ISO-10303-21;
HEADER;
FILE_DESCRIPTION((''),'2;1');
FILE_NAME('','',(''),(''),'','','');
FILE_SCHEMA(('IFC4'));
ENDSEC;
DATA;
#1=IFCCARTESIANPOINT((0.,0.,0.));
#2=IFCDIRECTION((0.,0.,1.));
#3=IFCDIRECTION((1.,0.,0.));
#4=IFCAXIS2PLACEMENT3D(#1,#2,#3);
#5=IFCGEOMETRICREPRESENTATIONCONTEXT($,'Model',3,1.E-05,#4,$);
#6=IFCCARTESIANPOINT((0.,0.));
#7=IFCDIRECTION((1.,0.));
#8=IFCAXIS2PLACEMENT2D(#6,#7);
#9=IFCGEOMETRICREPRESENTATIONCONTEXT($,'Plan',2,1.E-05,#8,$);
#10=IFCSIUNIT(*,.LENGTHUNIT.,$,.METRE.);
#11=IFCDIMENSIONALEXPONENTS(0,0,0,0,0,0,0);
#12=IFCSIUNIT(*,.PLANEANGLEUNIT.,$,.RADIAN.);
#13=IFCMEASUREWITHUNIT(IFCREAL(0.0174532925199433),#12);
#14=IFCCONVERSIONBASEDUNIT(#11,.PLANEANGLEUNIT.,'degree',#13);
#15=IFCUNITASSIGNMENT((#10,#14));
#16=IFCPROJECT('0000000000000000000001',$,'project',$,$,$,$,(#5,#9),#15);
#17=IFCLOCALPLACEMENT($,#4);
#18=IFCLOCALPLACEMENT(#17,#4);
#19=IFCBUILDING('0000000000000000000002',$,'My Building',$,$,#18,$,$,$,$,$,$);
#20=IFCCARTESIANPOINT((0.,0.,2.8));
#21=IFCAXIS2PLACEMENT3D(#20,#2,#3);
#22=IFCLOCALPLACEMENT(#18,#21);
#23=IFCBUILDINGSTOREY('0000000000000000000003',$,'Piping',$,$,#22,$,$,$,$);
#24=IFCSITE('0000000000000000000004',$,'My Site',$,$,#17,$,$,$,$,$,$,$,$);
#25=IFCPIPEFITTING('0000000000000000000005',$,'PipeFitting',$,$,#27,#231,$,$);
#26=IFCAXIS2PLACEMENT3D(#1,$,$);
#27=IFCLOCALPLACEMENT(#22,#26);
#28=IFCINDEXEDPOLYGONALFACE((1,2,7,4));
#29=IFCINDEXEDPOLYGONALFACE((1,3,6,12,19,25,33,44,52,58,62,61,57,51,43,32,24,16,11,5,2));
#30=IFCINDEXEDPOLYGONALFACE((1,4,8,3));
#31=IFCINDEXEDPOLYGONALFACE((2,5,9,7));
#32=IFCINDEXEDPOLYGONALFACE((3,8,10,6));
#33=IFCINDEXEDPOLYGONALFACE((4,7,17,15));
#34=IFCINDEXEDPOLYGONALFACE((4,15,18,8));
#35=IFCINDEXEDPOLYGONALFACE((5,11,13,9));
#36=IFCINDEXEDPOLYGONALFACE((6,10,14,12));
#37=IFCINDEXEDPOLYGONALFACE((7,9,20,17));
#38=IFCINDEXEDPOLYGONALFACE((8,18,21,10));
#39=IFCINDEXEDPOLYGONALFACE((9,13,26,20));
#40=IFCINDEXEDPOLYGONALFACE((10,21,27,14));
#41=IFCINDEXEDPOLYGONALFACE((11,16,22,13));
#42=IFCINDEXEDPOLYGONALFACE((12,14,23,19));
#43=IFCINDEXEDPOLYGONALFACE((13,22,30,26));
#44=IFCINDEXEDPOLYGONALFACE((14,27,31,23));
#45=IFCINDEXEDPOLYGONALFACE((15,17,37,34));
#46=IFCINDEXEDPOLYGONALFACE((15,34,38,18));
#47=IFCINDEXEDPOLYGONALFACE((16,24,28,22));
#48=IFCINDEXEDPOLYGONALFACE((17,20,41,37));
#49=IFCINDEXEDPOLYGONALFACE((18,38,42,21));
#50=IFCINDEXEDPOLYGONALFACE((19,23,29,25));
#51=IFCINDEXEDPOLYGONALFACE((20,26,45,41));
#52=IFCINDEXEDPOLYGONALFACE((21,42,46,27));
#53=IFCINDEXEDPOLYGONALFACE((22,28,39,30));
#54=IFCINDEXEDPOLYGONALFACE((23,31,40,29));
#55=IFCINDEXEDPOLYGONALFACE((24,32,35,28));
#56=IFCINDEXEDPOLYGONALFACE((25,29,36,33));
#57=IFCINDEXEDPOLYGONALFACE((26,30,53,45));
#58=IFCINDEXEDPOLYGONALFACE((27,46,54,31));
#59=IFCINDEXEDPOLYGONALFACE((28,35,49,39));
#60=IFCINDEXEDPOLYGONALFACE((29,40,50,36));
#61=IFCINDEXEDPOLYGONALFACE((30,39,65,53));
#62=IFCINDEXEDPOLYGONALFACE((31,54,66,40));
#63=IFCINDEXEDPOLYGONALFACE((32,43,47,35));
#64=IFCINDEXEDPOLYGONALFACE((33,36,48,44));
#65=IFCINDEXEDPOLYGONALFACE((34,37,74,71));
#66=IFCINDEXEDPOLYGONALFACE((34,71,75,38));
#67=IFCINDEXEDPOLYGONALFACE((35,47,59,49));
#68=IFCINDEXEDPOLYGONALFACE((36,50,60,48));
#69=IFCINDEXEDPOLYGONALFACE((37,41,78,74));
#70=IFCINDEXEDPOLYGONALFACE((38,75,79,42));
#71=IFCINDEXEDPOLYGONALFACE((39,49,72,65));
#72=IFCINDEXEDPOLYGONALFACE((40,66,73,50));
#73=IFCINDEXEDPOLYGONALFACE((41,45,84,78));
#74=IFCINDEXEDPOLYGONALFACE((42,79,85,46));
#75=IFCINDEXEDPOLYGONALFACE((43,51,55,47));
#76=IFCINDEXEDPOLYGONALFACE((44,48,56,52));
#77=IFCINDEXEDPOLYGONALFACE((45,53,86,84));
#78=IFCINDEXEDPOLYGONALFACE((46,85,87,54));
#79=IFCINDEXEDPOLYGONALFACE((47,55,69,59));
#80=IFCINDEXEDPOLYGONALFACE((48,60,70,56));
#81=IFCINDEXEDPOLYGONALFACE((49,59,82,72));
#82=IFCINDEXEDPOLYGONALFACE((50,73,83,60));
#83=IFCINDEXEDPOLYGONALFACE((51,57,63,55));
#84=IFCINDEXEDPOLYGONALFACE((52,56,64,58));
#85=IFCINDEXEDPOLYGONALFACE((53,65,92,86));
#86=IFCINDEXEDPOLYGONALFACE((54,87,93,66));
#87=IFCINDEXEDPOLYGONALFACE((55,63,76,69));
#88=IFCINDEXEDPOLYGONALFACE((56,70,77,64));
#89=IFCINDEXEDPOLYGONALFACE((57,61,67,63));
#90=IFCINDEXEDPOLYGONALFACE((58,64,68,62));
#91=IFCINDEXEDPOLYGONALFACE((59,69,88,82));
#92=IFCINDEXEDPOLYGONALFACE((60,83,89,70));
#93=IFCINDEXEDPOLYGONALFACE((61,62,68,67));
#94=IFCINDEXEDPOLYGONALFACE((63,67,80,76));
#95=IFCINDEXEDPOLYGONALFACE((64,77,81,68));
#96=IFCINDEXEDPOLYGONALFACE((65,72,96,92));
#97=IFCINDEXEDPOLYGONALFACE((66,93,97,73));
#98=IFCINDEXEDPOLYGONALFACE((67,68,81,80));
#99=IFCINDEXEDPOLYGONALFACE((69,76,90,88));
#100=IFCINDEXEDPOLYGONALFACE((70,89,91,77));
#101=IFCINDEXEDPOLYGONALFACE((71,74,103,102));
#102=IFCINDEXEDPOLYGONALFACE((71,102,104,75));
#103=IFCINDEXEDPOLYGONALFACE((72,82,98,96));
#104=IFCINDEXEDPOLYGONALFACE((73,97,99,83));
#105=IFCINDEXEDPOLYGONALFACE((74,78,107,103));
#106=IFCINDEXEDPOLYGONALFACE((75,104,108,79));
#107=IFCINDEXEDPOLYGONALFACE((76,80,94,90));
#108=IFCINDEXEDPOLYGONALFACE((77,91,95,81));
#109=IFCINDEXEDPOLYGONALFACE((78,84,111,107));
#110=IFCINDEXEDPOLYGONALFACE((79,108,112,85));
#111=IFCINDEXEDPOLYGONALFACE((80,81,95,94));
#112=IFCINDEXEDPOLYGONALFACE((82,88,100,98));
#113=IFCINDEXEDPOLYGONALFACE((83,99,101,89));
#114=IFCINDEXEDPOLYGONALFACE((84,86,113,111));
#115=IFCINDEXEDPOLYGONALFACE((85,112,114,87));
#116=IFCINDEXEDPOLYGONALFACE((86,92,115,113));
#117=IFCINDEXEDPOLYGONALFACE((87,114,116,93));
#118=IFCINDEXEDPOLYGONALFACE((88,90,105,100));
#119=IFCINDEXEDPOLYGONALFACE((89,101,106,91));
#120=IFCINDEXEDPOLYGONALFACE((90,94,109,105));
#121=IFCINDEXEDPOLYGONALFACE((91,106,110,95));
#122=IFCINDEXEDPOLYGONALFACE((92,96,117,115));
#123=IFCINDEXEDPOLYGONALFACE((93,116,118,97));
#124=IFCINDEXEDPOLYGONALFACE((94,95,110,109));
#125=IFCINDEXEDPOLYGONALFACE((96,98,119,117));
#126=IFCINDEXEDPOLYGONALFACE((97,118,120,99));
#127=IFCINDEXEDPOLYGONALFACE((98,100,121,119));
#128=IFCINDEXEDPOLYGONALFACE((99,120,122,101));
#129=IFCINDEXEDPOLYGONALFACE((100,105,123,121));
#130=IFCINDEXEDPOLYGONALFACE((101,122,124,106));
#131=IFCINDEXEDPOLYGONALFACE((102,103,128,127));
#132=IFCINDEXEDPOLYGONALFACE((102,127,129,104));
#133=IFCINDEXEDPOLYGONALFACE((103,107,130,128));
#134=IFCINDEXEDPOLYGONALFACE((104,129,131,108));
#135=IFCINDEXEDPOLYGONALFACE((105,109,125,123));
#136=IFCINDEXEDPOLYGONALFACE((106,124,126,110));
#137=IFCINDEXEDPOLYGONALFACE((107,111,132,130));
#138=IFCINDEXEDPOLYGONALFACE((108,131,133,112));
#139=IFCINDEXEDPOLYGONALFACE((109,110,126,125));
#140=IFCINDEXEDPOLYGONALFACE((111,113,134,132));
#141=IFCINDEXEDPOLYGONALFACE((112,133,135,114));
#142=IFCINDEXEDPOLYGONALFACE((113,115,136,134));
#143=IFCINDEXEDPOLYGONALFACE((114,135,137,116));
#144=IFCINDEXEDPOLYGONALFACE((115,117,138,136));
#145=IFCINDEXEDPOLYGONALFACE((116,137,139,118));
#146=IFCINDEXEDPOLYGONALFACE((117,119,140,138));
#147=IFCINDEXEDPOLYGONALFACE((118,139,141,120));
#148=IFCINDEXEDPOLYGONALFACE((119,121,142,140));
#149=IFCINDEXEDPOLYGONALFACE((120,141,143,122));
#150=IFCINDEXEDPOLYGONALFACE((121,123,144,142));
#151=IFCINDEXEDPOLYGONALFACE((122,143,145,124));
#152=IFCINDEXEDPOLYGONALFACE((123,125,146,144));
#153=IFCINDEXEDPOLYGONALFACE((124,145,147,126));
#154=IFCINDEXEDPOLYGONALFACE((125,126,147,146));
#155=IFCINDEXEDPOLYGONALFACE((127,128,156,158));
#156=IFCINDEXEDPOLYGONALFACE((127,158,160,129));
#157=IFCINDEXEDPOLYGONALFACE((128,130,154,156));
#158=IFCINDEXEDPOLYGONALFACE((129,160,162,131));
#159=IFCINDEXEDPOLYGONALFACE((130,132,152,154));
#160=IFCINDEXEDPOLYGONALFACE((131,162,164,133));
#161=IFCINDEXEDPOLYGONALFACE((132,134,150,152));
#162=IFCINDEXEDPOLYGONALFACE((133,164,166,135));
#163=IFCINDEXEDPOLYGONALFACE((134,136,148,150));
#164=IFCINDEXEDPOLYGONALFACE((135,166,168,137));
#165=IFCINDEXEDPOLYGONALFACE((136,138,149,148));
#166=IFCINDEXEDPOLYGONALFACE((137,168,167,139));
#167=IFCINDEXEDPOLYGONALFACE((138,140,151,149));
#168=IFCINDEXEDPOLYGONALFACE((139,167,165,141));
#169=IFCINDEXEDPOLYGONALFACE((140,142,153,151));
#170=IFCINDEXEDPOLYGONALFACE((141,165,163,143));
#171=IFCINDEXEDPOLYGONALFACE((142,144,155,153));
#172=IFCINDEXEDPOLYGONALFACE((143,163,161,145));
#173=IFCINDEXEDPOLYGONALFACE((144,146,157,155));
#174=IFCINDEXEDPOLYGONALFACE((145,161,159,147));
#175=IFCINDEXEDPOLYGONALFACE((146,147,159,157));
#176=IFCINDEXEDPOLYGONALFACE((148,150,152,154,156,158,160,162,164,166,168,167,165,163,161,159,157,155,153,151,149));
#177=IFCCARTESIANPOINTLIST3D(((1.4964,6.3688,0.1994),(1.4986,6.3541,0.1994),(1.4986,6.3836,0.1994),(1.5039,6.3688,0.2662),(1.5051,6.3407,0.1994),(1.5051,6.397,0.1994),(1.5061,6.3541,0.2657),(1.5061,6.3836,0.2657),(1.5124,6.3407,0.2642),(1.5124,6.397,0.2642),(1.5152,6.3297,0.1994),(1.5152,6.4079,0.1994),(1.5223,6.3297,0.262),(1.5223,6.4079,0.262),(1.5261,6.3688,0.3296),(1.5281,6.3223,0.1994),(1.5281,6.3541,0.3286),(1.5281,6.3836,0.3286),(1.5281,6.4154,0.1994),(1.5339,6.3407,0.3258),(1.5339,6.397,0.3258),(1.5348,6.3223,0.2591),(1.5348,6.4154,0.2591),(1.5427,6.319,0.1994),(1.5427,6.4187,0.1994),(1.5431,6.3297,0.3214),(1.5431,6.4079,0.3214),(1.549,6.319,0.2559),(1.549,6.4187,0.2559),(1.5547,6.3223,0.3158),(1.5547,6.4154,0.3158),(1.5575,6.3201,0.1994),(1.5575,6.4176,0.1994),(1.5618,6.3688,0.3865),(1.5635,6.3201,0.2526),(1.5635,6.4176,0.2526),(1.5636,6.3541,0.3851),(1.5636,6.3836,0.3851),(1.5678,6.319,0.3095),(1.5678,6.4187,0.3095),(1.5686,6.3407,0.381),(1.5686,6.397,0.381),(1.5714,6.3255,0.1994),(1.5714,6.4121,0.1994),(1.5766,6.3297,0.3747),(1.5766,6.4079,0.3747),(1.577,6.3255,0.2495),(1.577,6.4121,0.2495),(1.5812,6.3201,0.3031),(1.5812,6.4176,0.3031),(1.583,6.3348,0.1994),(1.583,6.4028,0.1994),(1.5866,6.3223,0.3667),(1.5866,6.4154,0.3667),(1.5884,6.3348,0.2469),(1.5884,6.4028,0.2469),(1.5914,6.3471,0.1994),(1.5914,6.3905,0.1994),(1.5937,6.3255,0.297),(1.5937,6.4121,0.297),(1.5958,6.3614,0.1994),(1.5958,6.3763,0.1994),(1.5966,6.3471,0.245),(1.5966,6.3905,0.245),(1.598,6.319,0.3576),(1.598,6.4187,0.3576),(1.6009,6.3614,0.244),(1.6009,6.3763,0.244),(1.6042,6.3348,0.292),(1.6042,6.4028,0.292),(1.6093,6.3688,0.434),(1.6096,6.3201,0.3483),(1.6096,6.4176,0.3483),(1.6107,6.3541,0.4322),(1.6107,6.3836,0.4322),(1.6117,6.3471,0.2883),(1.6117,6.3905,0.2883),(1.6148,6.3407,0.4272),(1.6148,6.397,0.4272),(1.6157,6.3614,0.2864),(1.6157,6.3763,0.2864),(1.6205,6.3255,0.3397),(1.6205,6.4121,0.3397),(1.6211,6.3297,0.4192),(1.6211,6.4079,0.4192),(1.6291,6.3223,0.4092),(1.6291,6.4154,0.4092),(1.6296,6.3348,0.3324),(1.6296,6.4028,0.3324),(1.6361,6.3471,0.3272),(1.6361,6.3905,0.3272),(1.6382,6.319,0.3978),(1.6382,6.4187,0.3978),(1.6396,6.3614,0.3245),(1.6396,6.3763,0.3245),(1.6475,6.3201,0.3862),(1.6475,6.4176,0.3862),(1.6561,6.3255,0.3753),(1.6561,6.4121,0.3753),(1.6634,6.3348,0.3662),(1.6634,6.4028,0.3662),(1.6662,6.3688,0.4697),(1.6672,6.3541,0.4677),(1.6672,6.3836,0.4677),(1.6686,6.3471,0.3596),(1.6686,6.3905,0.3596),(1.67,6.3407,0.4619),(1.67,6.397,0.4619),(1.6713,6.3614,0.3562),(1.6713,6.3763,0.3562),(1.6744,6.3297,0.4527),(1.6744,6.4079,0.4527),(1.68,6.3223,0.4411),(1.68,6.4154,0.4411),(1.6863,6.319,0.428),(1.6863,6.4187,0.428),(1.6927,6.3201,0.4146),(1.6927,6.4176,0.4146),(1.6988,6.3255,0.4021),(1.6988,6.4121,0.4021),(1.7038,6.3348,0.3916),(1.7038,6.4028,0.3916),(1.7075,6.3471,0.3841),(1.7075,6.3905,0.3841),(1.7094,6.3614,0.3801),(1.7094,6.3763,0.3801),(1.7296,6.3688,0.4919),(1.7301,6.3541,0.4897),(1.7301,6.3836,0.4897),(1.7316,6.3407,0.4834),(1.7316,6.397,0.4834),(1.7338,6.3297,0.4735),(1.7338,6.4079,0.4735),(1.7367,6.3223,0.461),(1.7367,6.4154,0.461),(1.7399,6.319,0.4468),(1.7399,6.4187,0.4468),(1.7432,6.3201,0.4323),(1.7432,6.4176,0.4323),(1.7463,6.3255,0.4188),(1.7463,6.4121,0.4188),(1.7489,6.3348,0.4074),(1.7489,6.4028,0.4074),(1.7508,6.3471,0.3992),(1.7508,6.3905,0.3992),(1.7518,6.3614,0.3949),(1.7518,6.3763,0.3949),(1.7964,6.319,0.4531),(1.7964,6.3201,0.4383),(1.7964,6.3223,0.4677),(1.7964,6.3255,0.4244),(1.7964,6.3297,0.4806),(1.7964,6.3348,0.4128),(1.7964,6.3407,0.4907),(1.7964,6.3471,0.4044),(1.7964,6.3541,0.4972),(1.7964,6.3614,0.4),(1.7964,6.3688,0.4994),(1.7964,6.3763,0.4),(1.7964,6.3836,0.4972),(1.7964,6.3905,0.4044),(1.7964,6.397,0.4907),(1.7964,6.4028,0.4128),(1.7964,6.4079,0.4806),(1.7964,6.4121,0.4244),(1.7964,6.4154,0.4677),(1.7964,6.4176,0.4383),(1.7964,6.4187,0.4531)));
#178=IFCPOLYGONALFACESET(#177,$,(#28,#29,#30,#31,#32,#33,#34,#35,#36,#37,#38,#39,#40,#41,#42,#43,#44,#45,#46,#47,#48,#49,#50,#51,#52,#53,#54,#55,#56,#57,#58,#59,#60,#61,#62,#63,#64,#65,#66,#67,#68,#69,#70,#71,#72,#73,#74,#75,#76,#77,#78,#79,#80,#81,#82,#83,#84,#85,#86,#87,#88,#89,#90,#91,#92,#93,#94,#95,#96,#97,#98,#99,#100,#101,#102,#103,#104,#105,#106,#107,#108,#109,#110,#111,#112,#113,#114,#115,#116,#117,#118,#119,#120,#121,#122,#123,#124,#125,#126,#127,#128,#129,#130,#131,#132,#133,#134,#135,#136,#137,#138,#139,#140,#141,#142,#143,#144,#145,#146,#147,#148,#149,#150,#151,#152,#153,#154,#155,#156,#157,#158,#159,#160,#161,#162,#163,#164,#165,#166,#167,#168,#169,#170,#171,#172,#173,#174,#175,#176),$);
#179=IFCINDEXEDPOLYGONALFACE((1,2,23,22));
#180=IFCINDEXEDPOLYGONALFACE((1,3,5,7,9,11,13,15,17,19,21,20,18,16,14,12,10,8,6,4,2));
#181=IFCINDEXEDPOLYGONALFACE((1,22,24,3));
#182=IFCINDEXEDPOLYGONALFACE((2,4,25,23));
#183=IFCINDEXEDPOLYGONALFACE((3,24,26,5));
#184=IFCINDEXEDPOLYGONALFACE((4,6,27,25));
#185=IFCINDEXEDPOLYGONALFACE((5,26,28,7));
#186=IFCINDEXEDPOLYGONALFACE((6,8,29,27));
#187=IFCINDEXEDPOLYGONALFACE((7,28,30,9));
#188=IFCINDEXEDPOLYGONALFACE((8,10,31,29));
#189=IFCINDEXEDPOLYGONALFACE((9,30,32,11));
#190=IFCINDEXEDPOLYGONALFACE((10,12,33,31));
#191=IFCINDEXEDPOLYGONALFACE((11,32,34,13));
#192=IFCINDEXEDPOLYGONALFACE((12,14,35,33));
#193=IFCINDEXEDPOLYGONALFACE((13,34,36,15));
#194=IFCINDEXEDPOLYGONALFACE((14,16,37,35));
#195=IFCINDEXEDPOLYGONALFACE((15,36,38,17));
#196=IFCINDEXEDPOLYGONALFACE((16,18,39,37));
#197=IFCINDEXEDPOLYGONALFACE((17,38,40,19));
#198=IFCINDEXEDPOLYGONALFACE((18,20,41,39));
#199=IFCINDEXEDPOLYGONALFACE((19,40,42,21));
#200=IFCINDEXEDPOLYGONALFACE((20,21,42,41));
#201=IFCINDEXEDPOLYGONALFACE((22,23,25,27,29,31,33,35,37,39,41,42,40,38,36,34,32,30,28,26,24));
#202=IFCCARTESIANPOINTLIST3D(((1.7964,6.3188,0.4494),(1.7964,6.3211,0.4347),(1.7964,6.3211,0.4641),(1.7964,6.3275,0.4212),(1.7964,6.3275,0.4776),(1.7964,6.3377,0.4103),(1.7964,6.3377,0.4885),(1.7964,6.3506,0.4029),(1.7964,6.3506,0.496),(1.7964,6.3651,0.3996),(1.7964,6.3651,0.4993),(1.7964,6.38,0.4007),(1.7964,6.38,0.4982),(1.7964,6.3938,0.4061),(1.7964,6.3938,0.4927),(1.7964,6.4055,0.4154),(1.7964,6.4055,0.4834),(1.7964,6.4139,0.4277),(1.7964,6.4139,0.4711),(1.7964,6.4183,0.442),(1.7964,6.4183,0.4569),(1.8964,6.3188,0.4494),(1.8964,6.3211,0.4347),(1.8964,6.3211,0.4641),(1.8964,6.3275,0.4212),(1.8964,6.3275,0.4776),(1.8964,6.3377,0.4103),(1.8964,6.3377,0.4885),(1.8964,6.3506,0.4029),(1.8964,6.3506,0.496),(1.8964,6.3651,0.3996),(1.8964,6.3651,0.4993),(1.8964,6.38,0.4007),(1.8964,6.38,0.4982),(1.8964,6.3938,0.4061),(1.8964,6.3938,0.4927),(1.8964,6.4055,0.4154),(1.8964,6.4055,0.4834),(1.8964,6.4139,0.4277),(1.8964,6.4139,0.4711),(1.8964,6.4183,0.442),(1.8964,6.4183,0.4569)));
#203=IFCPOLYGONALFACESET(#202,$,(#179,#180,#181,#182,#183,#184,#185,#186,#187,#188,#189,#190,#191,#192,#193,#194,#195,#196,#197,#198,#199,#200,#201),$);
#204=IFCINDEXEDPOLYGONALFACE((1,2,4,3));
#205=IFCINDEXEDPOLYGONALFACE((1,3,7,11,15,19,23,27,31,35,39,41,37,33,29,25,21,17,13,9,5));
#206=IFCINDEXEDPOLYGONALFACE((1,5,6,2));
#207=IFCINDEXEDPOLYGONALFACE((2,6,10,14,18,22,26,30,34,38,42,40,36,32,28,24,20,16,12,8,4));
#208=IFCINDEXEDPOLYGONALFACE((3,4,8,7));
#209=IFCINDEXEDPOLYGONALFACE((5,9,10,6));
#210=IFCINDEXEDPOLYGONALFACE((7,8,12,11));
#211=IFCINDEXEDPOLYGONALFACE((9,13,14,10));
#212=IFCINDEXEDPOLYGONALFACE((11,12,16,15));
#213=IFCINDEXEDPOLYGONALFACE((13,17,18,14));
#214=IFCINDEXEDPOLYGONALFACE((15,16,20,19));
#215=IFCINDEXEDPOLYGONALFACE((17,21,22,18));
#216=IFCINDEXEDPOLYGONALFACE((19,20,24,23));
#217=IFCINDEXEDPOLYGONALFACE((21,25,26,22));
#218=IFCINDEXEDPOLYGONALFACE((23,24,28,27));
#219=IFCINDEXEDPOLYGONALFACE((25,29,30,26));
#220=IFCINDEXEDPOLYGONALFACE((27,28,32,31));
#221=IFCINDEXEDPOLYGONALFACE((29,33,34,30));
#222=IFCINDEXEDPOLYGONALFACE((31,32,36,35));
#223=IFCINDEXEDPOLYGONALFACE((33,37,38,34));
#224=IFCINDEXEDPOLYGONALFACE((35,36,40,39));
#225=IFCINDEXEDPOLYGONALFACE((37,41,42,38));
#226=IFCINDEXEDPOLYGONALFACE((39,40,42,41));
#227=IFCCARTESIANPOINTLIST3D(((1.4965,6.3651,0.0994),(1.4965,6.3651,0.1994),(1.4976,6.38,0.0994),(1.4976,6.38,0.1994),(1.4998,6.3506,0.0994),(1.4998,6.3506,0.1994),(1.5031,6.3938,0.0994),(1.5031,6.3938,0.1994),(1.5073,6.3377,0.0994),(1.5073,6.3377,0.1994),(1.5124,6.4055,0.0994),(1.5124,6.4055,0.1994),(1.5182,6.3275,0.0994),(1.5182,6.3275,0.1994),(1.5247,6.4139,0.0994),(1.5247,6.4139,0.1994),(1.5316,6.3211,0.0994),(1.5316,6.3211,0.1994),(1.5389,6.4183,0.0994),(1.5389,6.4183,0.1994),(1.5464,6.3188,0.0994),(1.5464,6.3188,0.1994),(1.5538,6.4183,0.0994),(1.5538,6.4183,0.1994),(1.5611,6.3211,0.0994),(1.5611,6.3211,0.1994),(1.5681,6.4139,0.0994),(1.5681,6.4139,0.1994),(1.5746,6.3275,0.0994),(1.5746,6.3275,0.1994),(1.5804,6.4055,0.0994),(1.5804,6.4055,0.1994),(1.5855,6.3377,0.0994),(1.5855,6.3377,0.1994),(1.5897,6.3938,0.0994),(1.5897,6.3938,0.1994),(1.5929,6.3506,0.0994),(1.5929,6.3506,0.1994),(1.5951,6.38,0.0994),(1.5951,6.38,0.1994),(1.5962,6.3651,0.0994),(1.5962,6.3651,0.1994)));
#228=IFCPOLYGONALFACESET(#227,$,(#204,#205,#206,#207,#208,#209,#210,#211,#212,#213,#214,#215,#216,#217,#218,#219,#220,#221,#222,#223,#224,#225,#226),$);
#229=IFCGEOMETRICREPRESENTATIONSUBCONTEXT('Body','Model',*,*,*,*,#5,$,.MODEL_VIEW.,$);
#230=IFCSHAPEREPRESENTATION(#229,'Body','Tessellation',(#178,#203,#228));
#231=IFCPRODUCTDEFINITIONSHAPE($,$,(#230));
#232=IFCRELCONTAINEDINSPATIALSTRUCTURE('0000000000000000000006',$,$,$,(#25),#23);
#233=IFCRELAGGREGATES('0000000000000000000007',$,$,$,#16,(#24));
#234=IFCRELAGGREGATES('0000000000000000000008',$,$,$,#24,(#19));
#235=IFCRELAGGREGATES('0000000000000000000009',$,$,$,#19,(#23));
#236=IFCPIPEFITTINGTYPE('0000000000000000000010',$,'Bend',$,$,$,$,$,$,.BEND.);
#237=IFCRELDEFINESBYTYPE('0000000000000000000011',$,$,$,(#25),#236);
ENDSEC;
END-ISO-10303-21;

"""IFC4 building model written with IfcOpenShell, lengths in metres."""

from ifc_helpers import new_model, entity, si_unit, converted_unit, frame, origin_with_axes, origin_2d_with_axis, place, context, subcontext, project, spatial, circle, extrude, source, transform, mapped, type_object, type_shapes, element, save


model = new_model("IFC4")

# Units and contexts
model_context = context("Model", 3, precision=1e-05, world=origin_with_axes())
plan_context = context("Plan", 2, precision=1e-05, world=origin_2d_with_axis())
body_context = subcontext(model_context, "Body", "Model", "MODEL_VIEW")
ifc_project = project(units=[si_unit("LENGTHUNIT", "METRE"), converted_unit("PLANEANGLEUNIT", "degree", entity("IfcReal", 0.0174532925199433), si_unit("PLANEANGLEUNIT", "RADIAN"), dimensions=[0, 0, 0, 0, 0, 0, 0])], contexts=[model_context, plan_context])

# Site, building, storey
site_placement = place(None, origin_with_axes())
site = spatial("IfcSite", under=ifc_project, at=site_placement, Name="My Site")
building_placement = place(site_placement, origin_with_axes())
building = spatial("IfcBuilding", under=site, at=building_placement, Name="My Building")
storey_placement = place(building_placement, frame((0.0, 0.0, 2.8), z_axis=(0.0, 0.0, 1.0), x_axis=(1.0, 0.0, 0.0)))
storey = spatial("IfcBuildingStorey", under=building, at=storey_placement, Name="Piping")

# Pipe fitting
pipe_fitting_type_1 = type_object("IfcPipeFittingType", Name="Bend", PredefinedType="BEND")
shared_shape_1 = source(origin_with_axes(), body_context, "Body", "SolidModel", [
    entity("IfcSweptDiskSolid", entity("IfcIndexedPolyCurve", entity("IfcCartesianPointList3D", [[0.0, 0.0, 0.1], [0.0, -0.0732, 0.2768], [0.0, -0.25, 0.35]]), [entity("IfcArcIndex", [1, 2, 3])]), 0.05),
    extrude(circle(Radius=0.05), origin_with_axes(), (0.0, 0.0, 1.0), 0.1),
    extrude(circle(Radius=0.05), frame((0.0, -0.25, 0.35), z_axis=(0.0, -1.0, 0.0), x_axis=(1.0, 0.0, 0.0)), (0.0, 0.0, 1.0), 0.1),
])
type_shapes(pipe_fitting_type_1, [shared_shape_1])
for number, where, z_axis, x_axis, name in (
    (1, (1.8964, 6.3688, 0.4494), (-1.0, 0.0, 0.0), (0.0, -1.0, 0.0), "PipeFitting"),
):
    element("IfcPipeFitting", number, at=place(storey_placement, frame(where, z_axis=z_axis, x_axis=x_axis)), inside=storey, type_object=pipe_fitting_type_1, Name=name, context=body_context, shape_type="MappedRepresentation", body=[
        mapped(shared_shape_1, transform((0.0, 0.0, 0.0), x_axis=(1.0, 0.0, 0.0), y_axis=(0.0, 1.0, 0.0), z_axis=(0.0, 0.0, 1.0), scale=1.0)),
    ])

save(model, "model.ifc")
